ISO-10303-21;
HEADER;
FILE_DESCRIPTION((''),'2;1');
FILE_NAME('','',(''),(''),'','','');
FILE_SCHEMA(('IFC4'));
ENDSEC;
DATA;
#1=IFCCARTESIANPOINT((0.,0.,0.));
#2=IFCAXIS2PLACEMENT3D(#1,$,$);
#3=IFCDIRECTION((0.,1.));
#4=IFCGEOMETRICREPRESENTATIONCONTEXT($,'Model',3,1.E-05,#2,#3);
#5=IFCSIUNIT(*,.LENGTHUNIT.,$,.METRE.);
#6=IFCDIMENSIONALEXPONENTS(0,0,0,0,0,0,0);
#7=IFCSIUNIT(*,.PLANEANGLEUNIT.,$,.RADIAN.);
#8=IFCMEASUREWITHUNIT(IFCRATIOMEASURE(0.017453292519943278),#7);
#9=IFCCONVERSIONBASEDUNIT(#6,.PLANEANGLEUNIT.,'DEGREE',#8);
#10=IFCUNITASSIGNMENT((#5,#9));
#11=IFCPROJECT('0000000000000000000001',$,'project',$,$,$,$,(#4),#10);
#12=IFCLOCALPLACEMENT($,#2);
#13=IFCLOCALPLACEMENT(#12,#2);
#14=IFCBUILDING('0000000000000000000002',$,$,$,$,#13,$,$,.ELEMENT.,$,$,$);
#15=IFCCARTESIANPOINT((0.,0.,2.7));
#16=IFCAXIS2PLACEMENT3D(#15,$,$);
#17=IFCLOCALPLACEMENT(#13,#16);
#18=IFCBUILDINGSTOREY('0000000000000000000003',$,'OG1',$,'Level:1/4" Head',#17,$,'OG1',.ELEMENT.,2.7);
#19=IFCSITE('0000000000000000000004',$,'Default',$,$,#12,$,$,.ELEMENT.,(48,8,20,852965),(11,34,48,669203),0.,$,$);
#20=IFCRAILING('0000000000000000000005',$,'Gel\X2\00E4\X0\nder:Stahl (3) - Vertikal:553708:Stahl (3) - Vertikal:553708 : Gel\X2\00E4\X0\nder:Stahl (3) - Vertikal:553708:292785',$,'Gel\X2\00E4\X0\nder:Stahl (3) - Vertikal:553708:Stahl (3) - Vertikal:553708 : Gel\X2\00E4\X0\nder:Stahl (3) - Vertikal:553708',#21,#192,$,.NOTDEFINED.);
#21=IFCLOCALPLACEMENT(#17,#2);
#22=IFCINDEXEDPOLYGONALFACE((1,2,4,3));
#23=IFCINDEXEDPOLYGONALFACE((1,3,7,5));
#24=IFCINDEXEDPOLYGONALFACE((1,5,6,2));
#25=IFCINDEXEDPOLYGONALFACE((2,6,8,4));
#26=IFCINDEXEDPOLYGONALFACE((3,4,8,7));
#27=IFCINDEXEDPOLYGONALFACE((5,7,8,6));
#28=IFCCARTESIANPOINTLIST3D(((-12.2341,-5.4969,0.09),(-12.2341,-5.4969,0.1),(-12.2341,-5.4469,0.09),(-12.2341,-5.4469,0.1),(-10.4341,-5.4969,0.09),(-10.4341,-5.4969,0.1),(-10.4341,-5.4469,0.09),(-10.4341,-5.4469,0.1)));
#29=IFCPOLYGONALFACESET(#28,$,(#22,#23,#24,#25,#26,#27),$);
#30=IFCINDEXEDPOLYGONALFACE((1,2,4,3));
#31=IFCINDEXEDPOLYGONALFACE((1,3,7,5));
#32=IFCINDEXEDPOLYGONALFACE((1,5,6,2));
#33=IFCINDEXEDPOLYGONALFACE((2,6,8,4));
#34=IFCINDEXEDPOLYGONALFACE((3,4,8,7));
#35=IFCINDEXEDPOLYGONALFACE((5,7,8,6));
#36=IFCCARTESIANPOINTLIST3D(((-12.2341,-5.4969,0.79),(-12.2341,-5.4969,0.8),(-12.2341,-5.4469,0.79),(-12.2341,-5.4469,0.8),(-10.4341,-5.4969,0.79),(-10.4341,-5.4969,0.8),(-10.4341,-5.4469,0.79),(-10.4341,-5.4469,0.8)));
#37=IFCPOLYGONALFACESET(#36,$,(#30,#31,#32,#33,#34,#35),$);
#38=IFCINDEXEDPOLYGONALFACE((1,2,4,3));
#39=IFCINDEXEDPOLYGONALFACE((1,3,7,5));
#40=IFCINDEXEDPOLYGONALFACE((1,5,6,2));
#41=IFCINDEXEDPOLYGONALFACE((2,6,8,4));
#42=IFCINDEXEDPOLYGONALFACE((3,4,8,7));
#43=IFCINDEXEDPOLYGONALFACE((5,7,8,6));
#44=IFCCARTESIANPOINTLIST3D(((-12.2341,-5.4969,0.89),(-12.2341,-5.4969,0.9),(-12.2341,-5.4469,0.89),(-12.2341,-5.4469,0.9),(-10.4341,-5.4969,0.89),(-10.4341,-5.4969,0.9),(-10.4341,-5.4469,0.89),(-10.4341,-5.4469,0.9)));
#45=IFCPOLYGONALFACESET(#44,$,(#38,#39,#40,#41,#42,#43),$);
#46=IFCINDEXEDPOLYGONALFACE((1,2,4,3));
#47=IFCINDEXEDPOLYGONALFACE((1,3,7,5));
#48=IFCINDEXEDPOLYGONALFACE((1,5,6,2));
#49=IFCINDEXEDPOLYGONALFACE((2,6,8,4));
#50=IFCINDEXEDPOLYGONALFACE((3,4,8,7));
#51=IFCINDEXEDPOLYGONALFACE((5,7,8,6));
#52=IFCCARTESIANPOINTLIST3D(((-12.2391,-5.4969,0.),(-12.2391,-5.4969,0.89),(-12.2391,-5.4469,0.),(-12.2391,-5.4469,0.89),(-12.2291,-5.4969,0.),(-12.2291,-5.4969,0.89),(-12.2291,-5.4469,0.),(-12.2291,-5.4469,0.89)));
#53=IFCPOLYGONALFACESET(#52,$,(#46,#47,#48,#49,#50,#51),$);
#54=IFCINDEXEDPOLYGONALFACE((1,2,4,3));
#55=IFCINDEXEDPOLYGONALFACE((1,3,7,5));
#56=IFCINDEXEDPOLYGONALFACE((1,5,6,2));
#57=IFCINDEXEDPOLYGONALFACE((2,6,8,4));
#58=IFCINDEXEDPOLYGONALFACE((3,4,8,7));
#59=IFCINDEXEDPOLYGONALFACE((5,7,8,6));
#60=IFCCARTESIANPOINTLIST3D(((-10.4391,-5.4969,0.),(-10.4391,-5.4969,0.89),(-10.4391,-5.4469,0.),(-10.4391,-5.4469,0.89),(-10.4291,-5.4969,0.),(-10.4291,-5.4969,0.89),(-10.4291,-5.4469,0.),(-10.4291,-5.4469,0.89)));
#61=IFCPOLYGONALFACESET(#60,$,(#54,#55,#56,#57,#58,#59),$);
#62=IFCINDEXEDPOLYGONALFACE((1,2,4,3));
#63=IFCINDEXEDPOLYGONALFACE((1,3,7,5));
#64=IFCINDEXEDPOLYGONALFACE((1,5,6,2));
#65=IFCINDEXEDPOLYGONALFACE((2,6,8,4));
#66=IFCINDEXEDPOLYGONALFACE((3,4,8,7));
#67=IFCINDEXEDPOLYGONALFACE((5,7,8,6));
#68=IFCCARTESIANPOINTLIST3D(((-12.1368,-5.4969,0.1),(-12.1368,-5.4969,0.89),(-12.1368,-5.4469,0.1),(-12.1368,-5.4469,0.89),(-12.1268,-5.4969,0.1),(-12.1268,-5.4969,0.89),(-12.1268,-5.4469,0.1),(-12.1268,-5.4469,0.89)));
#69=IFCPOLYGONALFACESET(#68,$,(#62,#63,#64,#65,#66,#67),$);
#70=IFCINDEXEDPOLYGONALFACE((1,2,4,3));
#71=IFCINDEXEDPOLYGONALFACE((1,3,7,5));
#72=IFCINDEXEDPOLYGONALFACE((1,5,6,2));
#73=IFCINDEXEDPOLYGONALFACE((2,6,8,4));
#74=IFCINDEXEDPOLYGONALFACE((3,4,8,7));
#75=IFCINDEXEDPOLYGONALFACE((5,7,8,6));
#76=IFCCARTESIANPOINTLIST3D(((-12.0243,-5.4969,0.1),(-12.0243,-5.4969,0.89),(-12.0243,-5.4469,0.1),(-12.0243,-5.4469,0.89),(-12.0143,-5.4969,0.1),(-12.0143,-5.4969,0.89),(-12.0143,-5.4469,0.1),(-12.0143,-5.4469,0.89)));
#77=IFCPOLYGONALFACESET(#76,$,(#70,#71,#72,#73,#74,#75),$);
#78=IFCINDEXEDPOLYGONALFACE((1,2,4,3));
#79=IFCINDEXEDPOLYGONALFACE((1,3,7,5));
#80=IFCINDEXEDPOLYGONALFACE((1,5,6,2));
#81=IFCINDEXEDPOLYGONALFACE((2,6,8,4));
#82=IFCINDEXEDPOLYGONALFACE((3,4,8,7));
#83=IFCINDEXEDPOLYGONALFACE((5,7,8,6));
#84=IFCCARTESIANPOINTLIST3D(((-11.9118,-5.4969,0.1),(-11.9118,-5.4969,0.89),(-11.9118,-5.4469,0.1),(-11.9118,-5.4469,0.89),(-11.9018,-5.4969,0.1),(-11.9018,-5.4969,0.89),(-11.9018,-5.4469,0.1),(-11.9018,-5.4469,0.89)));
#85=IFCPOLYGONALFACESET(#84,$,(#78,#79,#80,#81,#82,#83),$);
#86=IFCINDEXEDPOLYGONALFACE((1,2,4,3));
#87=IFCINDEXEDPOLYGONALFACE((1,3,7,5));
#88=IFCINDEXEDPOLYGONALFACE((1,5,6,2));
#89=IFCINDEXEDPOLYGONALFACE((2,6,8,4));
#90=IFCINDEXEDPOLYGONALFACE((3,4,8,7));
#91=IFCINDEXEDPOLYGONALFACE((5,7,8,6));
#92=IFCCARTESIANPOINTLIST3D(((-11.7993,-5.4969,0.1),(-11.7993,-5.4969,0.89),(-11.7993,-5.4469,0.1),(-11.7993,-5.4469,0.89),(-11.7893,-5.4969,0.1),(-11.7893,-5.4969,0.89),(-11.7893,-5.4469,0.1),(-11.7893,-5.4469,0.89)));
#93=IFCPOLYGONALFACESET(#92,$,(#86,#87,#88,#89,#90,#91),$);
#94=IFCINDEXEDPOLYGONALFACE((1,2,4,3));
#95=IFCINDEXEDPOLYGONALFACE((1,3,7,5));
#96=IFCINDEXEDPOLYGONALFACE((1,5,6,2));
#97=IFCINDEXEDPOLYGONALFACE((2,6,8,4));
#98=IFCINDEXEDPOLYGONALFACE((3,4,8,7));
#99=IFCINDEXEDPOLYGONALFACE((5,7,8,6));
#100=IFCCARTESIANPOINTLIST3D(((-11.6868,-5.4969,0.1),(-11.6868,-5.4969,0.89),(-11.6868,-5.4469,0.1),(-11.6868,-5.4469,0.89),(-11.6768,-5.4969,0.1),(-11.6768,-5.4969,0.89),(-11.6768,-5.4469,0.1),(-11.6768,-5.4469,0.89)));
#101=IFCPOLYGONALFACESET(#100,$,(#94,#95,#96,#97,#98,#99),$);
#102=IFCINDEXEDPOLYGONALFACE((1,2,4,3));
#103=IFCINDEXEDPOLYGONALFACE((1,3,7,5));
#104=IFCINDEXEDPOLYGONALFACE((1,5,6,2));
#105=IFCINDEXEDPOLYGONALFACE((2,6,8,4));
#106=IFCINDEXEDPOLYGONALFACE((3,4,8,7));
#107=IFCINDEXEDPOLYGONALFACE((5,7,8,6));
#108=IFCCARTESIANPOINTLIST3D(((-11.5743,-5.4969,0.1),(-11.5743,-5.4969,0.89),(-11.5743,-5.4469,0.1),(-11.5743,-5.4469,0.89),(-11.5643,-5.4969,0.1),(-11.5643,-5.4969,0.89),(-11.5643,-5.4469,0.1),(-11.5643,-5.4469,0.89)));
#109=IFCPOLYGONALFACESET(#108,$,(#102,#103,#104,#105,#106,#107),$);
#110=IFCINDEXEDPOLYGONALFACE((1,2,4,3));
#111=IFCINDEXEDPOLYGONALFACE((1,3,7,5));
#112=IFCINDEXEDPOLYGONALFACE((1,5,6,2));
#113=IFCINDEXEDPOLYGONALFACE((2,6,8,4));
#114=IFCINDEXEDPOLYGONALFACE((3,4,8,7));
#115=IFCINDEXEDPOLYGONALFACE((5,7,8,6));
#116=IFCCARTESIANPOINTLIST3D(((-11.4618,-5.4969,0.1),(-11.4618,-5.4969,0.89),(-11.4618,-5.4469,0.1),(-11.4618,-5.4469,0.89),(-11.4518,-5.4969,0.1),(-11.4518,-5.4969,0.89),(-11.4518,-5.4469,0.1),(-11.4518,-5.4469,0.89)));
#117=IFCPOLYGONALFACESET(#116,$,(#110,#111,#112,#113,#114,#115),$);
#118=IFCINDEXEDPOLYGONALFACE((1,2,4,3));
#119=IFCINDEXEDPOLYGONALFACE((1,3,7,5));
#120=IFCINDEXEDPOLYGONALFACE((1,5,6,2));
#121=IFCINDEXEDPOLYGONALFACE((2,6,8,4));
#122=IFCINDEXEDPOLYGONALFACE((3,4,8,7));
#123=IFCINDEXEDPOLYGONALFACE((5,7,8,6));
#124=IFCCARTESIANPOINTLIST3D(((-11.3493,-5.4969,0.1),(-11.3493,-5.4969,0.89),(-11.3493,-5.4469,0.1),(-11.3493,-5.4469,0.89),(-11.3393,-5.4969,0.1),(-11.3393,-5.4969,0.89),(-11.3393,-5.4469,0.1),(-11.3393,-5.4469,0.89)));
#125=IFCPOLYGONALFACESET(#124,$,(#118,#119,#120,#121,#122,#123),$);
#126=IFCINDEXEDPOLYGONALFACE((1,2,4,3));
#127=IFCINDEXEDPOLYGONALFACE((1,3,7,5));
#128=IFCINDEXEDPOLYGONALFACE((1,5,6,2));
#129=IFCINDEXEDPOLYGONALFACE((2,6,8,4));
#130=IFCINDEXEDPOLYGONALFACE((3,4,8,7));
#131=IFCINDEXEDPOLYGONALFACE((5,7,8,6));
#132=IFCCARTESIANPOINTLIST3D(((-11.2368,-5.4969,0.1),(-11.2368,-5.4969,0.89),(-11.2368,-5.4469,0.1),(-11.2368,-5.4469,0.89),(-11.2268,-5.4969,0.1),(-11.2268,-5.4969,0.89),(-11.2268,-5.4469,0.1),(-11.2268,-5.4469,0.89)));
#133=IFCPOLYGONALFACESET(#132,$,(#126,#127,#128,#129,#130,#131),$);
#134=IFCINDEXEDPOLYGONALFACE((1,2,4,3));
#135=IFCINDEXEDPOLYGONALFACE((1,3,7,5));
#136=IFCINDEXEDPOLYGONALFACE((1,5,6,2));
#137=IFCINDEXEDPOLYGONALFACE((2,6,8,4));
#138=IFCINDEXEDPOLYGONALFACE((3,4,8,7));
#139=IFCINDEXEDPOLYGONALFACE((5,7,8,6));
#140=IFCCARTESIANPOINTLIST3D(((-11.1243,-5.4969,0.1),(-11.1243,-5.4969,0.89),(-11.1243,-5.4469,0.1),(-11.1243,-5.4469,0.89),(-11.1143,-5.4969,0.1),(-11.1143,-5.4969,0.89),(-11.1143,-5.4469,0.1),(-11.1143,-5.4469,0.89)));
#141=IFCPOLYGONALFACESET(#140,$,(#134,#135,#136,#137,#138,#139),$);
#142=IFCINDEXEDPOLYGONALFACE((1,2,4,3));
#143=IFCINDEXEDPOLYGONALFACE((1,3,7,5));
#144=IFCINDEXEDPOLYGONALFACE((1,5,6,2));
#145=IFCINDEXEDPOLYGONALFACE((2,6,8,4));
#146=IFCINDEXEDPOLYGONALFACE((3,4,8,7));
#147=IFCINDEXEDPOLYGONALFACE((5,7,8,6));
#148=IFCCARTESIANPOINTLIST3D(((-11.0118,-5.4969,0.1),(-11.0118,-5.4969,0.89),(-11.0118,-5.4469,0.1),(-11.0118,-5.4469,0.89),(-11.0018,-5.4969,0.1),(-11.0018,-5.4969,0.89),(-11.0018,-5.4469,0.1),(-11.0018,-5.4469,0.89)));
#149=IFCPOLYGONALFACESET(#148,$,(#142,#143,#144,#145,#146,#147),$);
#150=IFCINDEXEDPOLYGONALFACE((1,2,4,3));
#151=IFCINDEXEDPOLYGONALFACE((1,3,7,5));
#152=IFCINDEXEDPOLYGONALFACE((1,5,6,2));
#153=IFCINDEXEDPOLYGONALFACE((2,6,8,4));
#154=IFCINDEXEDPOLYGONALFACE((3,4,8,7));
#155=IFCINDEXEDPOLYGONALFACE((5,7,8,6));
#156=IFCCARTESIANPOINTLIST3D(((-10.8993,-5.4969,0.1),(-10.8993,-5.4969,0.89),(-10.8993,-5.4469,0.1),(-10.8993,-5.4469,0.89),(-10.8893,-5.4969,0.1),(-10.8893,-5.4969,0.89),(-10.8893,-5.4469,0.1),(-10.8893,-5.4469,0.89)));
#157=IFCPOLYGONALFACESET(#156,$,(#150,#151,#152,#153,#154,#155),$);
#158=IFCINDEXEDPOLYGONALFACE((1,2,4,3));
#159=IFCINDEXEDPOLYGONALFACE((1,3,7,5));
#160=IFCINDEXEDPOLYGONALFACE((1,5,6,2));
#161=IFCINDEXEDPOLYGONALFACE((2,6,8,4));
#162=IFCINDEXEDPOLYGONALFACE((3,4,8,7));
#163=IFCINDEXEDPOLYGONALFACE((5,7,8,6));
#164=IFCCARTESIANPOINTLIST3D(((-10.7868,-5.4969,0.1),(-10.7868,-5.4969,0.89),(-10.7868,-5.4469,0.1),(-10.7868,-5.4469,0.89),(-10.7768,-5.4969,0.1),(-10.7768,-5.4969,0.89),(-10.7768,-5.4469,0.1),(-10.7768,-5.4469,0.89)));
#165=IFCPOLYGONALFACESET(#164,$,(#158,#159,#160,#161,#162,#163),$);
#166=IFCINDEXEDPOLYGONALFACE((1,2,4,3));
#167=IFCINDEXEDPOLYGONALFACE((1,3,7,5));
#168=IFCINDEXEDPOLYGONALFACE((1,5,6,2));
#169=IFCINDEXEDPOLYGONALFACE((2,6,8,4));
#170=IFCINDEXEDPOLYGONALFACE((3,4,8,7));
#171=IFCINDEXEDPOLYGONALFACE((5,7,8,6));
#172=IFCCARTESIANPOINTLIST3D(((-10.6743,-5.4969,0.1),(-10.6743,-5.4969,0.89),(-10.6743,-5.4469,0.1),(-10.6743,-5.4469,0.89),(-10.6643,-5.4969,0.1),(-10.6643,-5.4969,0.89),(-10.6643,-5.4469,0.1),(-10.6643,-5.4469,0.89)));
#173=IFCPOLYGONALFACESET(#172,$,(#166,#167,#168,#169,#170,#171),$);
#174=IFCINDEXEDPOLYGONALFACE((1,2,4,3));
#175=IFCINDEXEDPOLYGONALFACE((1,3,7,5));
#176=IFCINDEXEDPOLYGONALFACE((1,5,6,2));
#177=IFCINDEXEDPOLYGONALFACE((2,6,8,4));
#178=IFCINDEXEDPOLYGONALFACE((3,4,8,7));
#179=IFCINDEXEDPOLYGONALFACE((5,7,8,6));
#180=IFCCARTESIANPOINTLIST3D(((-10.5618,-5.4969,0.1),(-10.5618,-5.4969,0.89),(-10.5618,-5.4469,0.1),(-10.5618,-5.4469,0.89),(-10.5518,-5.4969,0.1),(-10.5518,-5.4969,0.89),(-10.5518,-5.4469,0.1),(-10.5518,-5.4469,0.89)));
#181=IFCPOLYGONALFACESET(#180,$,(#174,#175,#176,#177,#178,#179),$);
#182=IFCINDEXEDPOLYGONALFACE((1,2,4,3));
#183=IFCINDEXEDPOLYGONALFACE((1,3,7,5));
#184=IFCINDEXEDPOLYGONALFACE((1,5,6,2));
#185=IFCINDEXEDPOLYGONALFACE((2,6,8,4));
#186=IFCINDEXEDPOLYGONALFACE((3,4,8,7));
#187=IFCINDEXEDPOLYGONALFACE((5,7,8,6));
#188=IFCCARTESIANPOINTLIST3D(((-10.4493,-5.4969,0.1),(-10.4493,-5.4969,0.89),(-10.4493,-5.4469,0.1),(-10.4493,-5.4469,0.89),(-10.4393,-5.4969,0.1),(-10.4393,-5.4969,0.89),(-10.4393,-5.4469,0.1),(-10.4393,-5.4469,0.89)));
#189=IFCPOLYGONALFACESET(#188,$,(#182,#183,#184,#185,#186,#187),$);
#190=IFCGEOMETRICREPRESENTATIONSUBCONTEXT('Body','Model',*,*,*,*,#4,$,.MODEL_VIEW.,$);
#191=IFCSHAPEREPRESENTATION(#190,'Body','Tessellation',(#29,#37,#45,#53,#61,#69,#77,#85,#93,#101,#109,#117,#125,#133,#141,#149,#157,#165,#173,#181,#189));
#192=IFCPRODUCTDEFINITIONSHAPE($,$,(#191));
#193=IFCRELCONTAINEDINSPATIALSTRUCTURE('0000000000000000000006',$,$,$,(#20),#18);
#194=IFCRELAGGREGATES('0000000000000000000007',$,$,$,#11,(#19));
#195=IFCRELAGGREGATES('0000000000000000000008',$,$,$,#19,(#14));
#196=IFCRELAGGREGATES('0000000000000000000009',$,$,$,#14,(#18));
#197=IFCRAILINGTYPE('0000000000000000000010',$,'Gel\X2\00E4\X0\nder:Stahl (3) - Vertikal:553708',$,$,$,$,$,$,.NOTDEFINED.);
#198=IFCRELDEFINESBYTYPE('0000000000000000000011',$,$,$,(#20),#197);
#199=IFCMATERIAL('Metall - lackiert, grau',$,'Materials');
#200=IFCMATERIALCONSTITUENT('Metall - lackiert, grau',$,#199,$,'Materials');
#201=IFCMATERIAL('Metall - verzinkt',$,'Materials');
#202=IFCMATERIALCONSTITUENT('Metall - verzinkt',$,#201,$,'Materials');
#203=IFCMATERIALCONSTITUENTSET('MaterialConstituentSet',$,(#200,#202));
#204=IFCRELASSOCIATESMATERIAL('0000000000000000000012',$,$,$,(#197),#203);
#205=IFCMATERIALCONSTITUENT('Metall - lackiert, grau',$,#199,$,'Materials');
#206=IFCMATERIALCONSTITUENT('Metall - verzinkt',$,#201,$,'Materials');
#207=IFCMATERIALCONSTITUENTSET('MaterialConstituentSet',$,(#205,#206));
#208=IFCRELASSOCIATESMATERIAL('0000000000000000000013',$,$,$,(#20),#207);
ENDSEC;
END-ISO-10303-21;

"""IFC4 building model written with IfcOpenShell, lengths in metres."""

from ifc_helpers import new_model, entity, si_unit, converted_unit, direction, frame, origin, place, context, subcontext, project, spatial, indexed_curve, outline, extrude, source, transform, mapped, material, constituent, constituent_set, type_object, type_shapes, element, save


model = new_model("IFC4")

# Units and contexts
model_context = context("Model", 3, precision=1e-05, world=origin(), true_north=direction((0.0, 1.0)))
body_context = subcontext(model_context, "Body", "Model", "MODEL_VIEW")
ifc_project = project(units=[si_unit("LENGTHUNIT", "METRE"), converted_unit("PLANEANGLEUNIT", "DEGREE", entity("IfcRatioMeasure", 0.017453292519943278), si_unit("PLANEANGLEUNIT", "RADIAN"), dimensions=[0, 0, 0, 0, 0, 0, 0])], contexts=[model_context])

# Site, building, storey
site_placement = place(None, origin())
site = spatial("IfcSite", under=ifc_project, at=site_placement, Name="Default", CompositionType="ELEMENT", RefLatitude=(48, 8, 20, 852965), RefLongitude=(11, 34, 48, 669203), RefElevation=0.0)
building_placement = place(site_placement, origin())
building = spatial("IfcBuilding", under=site, at=building_placement, CompositionType="ELEMENT")
storey_placement = place(building_placement, frame((0.0, 0.0, 2.7)))
storey = spatial("IfcBuildingStorey", under=building, at=storey_placement, Name="OG1", ObjectType="Level:1/4\" Head", LongName="OG1", CompositionType="ELEMENT", Elevation=2.7)

# Railing
ifc_material_1 = material(Name="Metall - lackiert, grau", Category="Materials")
ifc_material_2 = material(Name="Metall - verzinkt", Category="Materials")
ifc_constituent_1 = constituent(ifc_material_1, Name="Metall - lackiert, grau", Category="Materials")
ifc_constituent_2 = constituent(ifc_material_2, Name="Metall - verzinkt", Category="Materials")
ifc_constituent_set_1 = constituent_set(constituents=[ifc_constituent_1, ifc_constituent_2], Name="MaterialConstituentSet")
ifc_constituent_3 = constituent(ifc_material_1, Name="Metall - lackiert, grau", Category="Materials")
ifc_constituent_4 = constituent(ifc_material_2, Name="Metall - verzinkt", Category="Materials")
ifc_constituent_set_2 = constituent_set(constituents=[ifc_constituent_3, ifc_constituent_4], Name="MaterialConstituentSet")
railing_type_1 = type_object("IfcRailingType", Name="Geländer:Stahl (3) - Vertikal:553708", PredefinedType="NOTDEFINED", material=ifc_constituent_set_2)
shared_shape_1 = source(origin(), body_context, "Body", "SweptSolid", [
    extrude(outline(indexed_curve([(-0.025, -0.9), (0.025, -0.9), (0.025, 0.9), (-0.025, 0.9), (-0.025, -0.9)], self_intersect=False)), frame((-11.3341, -5.4719, 2.79), z_axis=(0.0, 0.0, 1.0), x_axis=(0.0, 1.0, 0.0)), (0.0, 0.0, 1.0), 0.01),
    extrude(outline(indexed_curve([(-0.025, -0.9), (0.025, -0.9), (0.025, 0.9), (-0.025, 0.9), (-0.025, -0.9)], self_intersect=False)), frame((-11.3341, -5.4719, 3.49), z_axis=(0.0, 0.0, 1.0), x_axis=(0.0, 1.0, 0.0)), (0.0, 0.0, 1.0), 0.01),
    extrude(outline(indexed_curve([(-0.025, -0.9), (0.025, -0.9), (0.025, 0.9), (-0.025, 0.9), (-0.025, -0.9)], self_intersect=False)), frame((-11.3341, -5.4719, 3.59), z_axis=(0.0, 0.0, 1.0), x_axis=(0.0, 1.0, 0.0)), (0.0, 0.0, 1.0), 0.01),
    extrude(outline(indexed_curve([(-0.025, -0.005), (0.025, -0.005), (0.025, 0.005), (-0.025, 0.005), (-0.025, -0.005)], self_intersect=False)), frame((-12.2341, -5.4719, 2.7), z_axis=(0.0, 0.0, 1.0), x_axis=(0.0, 1.0, 0.0)), (0.0, 0.0, 1.0), 0.89),
    extrude(outline(indexed_curve([(-0.025, -0.005), (0.025, -0.005), (0.025, 0.005), (-0.025, 0.005), (-0.025, -0.005)], self_intersect=False)), frame((-10.4341, -5.4719, 2.7), z_axis=(0.0, 0.0, 1.0), x_axis=(0.0, 1.0, 0.0)), (0.0, 0.0, 1.0), 0.89),
    extrude(outline(indexed_curve([(-0.025, -0.005), (0.025, -0.005), (0.025, 0.005), (-0.025, 0.005), (-0.025, -0.005)], self_intersect=False)), frame((-12.1318, -5.4719, 2.8), z_axis=(0.0, 0.0, 1.0), x_axis=(0.0, 1.0, 0.0)), (0.0, 0.0, 1.0), 0.79),
    extrude(outline(indexed_curve([(-0.025, -0.005), (0.025, -0.005), (0.025, 0.005), (-0.025, 0.005), (-0.025, -0.005)], self_intersect=False)), frame((-12.0193, -5.4719, 2.8), z_axis=(0.0, 0.0, 1.0), x_axis=(0.0, 1.0, 0.0)), (0.0, 0.0, 1.0), 0.79),
    extrude(outline(indexed_curve([(-0.025, -0.005), (0.025, -0.005), (0.025, 0.005), (-0.025, 0.005), (-0.025, -0.005)], self_intersect=False)), frame((-11.9068, -5.4719, 2.8), z_axis=(0.0, 0.0, 1.0), x_axis=(0.0, 1.0, 0.0)), (0.0, 0.0, 1.0), 0.79),
    extrude(outline(indexed_curve([(-0.025, -0.005), (0.025, -0.005), (0.025, 0.005), (-0.025, 0.005), (-0.025, -0.005)], self_intersect=False)), frame((-11.7943, -5.4719, 2.8), z_axis=(0.0, 0.0, 1.0), x_axis=(0.0, 1.0, 0.0)), (0.0, 0.0, 1.0), 0.79),
    extrude(outline(indexed_curve([(-0.025, -0.005), (0.025, -0.005), (0.025, 0.005), (-0.025, 0.005), (-0.025, -0.005)], self_intersect=False)), frame((-11.6818, -5.4719, 2.8), z_axis=(0.0, 0.0, 1.0), x_axis=(0.0, 1.0, 0.0)), (0.0, 0.0, 1.0), 0.79),
    extrude(outline(indexed_curve([(-0.025, -0.005), (0.025, -0.005), (0.025, 0.005), (-0.025, 0.005), (-0.025, -0.005)], self_intersect=False)), frame((-11.5693, -5.4719, 2.8), z_axis=(0.0, 0.0, 1.0), x_axis=(0.0, 1.0, 0.0)), (0.0, 0.0, 1.0), 0.79),
    extrude(outline(indexed_curve([(-0.025, -0.005), (0.025, -0.005), (0.025, 0.005), (-0.025, 0.005), (-0.025, -0.005)], self_intersect=False)), frame((-11.4568, -5.4719, 2.8), z_axis=(0.0, 0.0, 1.0), x_axis=(0.0, 1.0, 0.0)), (0.0, 0.0, 1.0), 0.79),
    extrude(outline(indexed_curve([(-0.025, -0.005), (0.025, -0.005), (0.025, 0.005), (-0.025, 0.005), (-0.025, -0.005)], self_intersect=False)), frame((-11.3443, -5.4719, 2.8), z_axis=(0.0, 0.0, 1.0), x_axis=(0.0, 1.0, 0.0)), (0.0, 0.0, 1.0), 0.79),
    extrude(outline(indexed_curve([(-0.025, -0.005), (0.025, -0.005), (0.025, 0.005), (-0.025, 0.005), (-0.025, -0.005)], self_intersect=False)), frame((-11.2318, -5.4719, 2.8), z_axis=(0.0, 0.0, 1.0), x_axis=(0.0, 1.0, 0.0)), (0.0, 0.0, 1.0), 0.79),
    extrude(outline(indexed_curve([(-0.025, -0.005), (0.025, -0.005), (0.025, 0.005), (-0.025, 0.005), (-0.025, -0.005)], self_intersect=False)), frame((-11.1193, -5.4719, 2.8), z_axis=(0.0, 0.0, 1.0), x_axis=(0.0, 1.0, 0.0)), (0.0, 0.0, 1.0), 0.79),
    extrude(outline(indexed_curve([(-0.025, -0.005), (0.025, -0.005), (0.025, 0.005), (-0.025, 0.005), (-0.025, -0.005)], self_intersect=False)), frame((-11.0068, -5.4719, 2.8), z_axis=(0.0, 0.0, 1.0), x_axis=(0.0, 1.0, 0.0)), (0.0, 0.0, 1.0), 0.79),
    extrude(outline(indexed_curve([(-0.025, -0.005), (0.025, -0.005), (0.025, 0.005), (-0.025, 0.005), (-0.025, -0.005)], self_intersect=False)), frame((-10.8943, -5.4719, 2.8), z_axis=(0.0, 0.0, 1.0), x_axis=(0.0, 1.0, 0.0)), (0.0, 0.0, 1.0), 0.79),
    extrude(outline(indexed_curve([(-0.025, -0.005), (0.025, -0.005), (0.025, 0.005), (-0.025, 0.005), (-0.025, -0.005)], self_intersect=False)), frame((-10.7818, -5.4719, 2.8), z_axis=(0.0, 0.0, 1.0), x_axis=(0.0, 1.0, 0.0)), (0.0, 0.0, 1.0), 0.79),
    extrude(outline(indexed_curve([(-0.025, -0.005), (0.025, -0.005), (0.025, 0.005), (-0.025, 0.005), (-0.025, -0.005)], self_intersect=False)), frame((-10.6693, -5.4719, 2.8), z_axis=(0.0, 0.0, 1.0), x_axis=(0.0, 1.0, 0.0)), (0.0, 0.0, 1.0), 0.79),
    extrude(outline(indexed_curve([(-0.025, -0.005), (0.025, -0.005), (0.025, 0.005), (-0.025, 0.005), (-0.025, -0.005)], self_intersect=False)), frame((-10.5568, -5.4719, 2.8), z_axis=(0.0, 0.0, 1.0), x_axis=(0.0, 1.0, 0.0)), (0.0, 0.0, 1.0), 0.79),
    extrude(outline(indexed_curve([(-0.025, -0.005), (0.025, -0.005), (0.025, 0.005), (-0.025, 0.005), (-0.025, -0.005)], self_intersect=False)), frame((-10.4443, -5.4719, 2.8), z_axis=(0.0, 0.0, 1.0), x_axis=(0.0, 1.0, 0.0)), (0.0, 0.0, 1.0), 0.79),
])
type_shapes(railing_type_1, [shared_shape_1])
railing_1_placement = place(storey_placement, frame((0.0, 0.0, -2.7)))
element("IfcRailing", 1, at=railing_1_placement, inside=storey, type_object=railing_type_1, material=ifc_constituent_set_1, Name="Geländer:Stahl (3) - Vertikal:553708:Stahl (3) - Vertikal:553708 : Geländer:Stahl (3) - Vertikal:553708:292785", ObjectType="Geländer:Stahl (3) - Vertikal:553708:Stahl (3) - Vertikal:553708 : Geländer:Stahl (3) - Vertikal:553708", PredefinedType="NOTDEFINED", context=body_context, shape_type="MappedRepresentation", body=[
    mapped(shared_shape_1, transform((0.0, 0.0, 0.0), scale=1.0)),
])

save(model, "model.ifc")
